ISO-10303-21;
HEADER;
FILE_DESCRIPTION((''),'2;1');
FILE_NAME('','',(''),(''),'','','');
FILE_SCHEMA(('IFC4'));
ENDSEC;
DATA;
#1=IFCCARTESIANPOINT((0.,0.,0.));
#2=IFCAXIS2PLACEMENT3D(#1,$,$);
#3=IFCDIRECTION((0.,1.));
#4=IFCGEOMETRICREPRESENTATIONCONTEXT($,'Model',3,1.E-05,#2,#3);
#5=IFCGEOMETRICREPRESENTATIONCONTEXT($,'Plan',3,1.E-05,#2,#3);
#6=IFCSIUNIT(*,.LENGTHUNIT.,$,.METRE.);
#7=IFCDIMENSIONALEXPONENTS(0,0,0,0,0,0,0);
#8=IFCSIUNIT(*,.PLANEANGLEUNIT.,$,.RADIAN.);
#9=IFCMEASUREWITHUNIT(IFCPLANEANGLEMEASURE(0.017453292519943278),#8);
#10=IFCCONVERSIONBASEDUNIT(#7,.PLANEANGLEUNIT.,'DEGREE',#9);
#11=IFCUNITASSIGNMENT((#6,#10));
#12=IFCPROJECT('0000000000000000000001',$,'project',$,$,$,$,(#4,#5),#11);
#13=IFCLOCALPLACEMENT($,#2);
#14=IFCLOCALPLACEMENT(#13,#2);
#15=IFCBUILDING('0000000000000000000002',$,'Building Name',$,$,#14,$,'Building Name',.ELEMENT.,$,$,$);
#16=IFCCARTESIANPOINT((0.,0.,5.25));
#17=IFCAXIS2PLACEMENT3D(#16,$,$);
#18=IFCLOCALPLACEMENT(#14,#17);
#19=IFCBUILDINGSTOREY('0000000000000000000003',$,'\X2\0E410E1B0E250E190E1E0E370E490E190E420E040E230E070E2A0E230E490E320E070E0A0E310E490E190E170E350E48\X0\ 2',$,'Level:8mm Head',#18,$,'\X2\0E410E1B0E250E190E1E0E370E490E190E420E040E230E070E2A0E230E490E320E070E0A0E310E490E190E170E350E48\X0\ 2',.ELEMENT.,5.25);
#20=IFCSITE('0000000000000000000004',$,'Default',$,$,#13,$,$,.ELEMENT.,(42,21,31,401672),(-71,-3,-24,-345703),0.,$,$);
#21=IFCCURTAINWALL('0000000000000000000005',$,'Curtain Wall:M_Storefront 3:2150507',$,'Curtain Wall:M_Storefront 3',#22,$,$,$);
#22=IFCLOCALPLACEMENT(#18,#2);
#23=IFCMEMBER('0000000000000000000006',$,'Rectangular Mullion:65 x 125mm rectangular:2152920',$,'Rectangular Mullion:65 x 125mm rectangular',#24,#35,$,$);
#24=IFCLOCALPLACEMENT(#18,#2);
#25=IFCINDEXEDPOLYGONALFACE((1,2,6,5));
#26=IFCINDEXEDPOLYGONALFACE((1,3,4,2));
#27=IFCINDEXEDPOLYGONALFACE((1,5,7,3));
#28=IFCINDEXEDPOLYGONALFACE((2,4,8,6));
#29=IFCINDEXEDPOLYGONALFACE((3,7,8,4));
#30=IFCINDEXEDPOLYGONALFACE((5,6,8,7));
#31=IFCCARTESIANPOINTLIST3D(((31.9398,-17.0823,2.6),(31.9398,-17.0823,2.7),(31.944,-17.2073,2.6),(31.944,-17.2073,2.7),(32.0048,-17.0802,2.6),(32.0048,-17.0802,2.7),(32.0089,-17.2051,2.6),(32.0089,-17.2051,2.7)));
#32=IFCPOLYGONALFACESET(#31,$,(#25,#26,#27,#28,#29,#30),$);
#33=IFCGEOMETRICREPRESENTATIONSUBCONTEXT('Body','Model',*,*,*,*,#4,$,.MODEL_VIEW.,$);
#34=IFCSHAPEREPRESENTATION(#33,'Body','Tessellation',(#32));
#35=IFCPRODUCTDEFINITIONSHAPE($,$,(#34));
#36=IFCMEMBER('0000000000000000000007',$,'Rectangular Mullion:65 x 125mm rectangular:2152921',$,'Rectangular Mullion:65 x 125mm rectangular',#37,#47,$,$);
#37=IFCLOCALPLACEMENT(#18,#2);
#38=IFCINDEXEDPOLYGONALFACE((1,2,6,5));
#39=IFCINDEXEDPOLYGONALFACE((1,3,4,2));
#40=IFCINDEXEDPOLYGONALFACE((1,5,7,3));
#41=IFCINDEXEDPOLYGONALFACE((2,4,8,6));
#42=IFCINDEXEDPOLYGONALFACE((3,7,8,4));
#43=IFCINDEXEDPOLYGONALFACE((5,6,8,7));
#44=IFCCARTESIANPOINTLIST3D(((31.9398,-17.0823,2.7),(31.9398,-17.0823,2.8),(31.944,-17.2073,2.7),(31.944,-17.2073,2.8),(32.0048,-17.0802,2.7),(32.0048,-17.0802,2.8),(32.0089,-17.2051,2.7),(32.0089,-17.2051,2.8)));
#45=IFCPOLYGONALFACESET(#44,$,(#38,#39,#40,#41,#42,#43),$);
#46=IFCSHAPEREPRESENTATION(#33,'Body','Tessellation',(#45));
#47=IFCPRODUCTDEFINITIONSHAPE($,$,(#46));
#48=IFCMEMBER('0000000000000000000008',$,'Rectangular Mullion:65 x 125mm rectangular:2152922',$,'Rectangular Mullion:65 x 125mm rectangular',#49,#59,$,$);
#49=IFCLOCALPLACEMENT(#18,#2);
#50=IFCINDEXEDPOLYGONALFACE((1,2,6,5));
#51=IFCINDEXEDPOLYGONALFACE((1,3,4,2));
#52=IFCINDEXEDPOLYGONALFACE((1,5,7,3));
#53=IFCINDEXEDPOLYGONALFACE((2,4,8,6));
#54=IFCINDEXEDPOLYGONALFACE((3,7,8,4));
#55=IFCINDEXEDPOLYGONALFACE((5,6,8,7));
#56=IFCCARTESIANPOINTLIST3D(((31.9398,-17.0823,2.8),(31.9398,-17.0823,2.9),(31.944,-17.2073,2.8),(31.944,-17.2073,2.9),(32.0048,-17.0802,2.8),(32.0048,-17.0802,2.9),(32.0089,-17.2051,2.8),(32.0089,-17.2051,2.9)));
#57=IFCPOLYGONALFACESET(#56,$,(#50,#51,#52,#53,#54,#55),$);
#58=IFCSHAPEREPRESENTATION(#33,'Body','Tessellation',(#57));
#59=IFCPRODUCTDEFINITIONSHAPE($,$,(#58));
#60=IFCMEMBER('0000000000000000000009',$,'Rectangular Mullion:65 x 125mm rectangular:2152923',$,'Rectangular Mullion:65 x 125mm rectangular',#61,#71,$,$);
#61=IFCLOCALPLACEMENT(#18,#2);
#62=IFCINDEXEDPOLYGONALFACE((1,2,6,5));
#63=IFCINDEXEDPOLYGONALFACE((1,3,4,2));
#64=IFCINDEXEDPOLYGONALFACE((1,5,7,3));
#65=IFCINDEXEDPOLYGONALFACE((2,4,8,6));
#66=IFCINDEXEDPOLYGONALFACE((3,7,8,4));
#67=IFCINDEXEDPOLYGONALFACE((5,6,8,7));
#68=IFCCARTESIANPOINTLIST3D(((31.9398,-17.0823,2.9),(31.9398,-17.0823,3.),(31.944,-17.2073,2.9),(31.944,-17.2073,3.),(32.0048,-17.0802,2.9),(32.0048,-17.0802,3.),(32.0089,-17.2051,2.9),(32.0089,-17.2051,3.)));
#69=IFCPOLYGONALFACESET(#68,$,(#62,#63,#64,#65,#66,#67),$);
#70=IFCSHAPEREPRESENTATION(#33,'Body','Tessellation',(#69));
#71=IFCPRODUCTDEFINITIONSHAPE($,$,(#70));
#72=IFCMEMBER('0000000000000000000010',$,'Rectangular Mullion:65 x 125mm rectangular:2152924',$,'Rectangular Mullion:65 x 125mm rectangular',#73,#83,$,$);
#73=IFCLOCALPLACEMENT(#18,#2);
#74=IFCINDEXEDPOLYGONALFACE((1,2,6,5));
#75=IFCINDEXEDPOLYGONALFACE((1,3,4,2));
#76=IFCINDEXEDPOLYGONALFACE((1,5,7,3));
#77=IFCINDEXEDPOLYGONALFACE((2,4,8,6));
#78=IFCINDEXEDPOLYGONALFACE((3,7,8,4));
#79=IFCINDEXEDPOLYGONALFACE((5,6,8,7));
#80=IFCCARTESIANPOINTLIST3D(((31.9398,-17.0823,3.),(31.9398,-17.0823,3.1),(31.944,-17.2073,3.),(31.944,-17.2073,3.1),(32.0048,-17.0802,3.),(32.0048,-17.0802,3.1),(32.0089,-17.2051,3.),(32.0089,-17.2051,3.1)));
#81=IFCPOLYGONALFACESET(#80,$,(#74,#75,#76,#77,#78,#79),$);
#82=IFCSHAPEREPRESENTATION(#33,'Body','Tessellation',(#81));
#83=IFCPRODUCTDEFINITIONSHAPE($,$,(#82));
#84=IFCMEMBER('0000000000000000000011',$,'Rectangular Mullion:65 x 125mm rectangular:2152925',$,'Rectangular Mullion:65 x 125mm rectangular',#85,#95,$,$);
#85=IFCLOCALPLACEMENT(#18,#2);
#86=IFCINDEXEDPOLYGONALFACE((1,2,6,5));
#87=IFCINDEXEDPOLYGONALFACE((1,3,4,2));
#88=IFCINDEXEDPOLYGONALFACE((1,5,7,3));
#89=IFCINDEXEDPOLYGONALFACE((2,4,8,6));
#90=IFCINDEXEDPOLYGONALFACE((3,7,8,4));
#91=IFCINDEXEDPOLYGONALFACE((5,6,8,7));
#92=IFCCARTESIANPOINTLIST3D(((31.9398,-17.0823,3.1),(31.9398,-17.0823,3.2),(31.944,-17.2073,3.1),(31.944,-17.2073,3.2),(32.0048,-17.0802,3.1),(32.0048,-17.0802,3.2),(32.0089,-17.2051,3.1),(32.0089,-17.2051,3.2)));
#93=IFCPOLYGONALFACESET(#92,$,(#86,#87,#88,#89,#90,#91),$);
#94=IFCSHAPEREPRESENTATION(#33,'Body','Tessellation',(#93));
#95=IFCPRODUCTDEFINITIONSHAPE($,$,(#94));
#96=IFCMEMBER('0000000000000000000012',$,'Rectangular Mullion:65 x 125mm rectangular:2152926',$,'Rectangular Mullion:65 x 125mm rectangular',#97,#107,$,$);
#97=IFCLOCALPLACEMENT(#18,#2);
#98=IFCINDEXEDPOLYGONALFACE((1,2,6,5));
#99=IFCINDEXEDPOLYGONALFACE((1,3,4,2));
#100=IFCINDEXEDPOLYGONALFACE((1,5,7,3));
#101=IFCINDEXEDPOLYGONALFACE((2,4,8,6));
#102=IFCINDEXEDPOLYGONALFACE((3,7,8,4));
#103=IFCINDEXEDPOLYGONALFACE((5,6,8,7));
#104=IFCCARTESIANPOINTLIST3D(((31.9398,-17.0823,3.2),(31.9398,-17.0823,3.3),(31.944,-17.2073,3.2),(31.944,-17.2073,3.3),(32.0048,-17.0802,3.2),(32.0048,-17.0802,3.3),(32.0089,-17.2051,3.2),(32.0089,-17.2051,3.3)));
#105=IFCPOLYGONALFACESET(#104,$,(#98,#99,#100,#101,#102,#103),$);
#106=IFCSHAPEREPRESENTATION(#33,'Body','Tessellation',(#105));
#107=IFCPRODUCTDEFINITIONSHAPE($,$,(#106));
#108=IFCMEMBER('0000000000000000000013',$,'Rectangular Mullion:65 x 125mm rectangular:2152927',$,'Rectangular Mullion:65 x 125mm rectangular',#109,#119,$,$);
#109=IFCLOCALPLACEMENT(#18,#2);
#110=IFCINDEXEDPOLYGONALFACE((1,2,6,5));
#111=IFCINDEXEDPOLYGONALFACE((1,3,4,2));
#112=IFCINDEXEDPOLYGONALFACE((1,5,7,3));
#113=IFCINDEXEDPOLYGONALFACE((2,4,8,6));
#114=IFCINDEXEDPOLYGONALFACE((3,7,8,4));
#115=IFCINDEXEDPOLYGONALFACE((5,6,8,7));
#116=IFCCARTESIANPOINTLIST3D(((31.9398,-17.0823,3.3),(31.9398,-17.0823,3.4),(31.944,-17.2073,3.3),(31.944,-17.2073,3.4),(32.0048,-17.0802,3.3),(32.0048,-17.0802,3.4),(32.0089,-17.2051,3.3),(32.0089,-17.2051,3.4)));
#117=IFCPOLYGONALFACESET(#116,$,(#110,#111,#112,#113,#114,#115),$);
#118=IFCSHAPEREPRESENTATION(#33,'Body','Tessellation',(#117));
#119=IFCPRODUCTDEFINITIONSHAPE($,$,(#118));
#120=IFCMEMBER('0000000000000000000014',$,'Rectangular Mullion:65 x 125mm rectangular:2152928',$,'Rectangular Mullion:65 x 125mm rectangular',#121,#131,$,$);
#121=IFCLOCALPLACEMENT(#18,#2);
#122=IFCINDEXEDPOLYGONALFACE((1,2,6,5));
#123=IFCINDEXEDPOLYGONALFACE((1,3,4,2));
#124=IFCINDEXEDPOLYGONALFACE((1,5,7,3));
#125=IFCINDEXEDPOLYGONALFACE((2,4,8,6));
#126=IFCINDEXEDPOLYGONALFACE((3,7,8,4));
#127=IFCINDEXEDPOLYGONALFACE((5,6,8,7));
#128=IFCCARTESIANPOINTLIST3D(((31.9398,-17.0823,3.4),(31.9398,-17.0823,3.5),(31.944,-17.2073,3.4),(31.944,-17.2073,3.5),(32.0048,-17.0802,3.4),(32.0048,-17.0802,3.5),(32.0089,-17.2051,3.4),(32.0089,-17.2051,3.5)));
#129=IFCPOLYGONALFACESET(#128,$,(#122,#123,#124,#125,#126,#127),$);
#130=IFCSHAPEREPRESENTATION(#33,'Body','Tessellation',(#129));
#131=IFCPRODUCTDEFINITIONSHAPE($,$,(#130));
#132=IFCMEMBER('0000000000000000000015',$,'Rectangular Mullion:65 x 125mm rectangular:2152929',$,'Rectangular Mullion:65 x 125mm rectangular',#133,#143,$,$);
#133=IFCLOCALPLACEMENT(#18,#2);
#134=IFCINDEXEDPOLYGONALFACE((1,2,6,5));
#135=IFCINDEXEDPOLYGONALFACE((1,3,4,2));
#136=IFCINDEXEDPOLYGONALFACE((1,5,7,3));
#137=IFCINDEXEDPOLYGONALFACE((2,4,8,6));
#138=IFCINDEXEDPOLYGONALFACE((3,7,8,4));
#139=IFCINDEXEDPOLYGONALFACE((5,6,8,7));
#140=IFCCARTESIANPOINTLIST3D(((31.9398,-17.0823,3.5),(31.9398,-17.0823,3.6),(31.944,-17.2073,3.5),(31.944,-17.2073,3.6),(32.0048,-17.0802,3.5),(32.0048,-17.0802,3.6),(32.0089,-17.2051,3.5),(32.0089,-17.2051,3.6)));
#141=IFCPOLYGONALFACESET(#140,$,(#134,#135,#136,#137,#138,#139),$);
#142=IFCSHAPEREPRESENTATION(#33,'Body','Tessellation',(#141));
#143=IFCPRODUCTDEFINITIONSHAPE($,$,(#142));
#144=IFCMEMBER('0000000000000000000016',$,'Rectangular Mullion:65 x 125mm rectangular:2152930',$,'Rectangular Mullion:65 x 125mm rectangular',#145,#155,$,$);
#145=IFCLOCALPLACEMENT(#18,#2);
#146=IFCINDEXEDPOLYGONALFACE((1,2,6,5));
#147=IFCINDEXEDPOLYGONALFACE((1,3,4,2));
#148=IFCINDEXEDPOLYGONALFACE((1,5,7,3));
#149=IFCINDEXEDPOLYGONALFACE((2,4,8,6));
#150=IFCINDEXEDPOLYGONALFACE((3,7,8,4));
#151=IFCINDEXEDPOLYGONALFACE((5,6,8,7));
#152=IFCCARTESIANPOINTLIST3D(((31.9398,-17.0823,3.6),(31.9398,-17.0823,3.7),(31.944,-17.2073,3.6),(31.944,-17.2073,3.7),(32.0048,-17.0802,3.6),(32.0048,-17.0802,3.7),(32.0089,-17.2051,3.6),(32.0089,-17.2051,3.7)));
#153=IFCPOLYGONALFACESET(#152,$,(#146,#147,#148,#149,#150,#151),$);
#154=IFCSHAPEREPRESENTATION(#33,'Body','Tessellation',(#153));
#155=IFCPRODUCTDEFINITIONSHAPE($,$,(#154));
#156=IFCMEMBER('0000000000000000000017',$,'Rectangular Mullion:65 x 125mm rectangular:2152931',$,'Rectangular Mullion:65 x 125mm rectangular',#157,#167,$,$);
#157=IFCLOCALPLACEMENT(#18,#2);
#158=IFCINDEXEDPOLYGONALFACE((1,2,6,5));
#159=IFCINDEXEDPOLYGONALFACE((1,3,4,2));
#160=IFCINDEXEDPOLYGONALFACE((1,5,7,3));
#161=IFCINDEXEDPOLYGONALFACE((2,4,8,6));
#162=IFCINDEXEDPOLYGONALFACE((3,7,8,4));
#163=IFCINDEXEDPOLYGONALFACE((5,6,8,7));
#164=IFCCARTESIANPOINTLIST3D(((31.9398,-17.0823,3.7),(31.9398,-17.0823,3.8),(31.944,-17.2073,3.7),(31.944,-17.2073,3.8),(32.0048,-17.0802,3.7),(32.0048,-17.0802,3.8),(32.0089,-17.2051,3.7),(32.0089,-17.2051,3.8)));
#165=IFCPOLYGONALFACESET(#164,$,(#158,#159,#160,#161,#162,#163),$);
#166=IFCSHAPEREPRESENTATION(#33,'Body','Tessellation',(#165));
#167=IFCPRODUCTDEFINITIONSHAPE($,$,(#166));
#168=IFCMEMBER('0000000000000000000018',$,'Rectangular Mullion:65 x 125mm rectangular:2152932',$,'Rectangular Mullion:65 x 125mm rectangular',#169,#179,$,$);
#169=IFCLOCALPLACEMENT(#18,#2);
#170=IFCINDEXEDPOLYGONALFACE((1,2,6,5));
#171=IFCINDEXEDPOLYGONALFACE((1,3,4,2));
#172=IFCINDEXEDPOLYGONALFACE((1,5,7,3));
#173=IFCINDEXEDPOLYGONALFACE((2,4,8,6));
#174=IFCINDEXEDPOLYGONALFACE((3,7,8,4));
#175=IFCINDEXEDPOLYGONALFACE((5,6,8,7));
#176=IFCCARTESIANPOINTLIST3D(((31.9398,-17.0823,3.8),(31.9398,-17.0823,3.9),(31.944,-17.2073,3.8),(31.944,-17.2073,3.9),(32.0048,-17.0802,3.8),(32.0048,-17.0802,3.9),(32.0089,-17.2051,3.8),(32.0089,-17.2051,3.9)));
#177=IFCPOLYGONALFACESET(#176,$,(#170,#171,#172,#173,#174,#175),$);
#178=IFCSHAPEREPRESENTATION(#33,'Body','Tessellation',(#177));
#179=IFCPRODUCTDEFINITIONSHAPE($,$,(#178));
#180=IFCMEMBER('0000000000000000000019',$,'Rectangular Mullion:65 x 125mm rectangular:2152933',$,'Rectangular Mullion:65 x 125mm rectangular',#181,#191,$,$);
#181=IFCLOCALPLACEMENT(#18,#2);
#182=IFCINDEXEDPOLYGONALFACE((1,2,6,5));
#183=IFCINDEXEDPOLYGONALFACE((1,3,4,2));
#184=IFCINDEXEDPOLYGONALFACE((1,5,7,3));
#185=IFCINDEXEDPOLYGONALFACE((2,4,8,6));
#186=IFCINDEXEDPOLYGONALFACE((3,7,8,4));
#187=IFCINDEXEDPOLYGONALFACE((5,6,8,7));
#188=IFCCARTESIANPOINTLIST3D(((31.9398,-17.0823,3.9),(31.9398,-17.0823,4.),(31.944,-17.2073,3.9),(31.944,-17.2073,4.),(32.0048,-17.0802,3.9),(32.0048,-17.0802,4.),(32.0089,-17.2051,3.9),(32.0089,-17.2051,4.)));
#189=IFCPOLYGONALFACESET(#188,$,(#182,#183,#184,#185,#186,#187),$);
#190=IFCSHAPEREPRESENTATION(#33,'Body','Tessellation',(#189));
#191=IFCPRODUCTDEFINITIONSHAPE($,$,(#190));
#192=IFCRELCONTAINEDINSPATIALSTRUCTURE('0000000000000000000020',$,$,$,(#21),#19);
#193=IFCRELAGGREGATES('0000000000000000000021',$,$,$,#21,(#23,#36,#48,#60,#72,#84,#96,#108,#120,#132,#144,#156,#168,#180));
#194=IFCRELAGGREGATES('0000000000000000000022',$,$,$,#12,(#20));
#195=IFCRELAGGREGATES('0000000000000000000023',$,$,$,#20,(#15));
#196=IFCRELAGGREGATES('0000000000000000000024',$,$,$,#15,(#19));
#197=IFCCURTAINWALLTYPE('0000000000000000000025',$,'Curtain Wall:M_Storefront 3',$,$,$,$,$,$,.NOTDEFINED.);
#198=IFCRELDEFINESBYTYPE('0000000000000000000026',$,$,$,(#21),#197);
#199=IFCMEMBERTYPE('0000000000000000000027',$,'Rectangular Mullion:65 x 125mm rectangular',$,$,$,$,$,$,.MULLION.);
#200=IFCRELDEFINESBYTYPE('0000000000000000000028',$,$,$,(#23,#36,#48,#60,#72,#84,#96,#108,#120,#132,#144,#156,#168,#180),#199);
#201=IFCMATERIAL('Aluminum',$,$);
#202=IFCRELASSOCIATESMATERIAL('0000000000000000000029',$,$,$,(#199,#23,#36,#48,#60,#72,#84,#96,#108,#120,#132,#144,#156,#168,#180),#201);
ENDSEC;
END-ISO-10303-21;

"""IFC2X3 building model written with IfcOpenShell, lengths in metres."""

from ifc_helpers import new_model, entity, si_unit, converted_unit, direction, frame, origin, origin_2d_with_axis, place, context, subcontext, project, spatial, rectangle, extrude, source, transform, mapped, material, type_object, type_shapes, element, aggregate, save


model = new_model("IFC2X3")

# Units and contexts
model_context = context("Model", 3, precision=1e-05, world=origin(), true_north=direction((0.0, 1.0)))
plan_context = context("Plan", 3, precision=1e-05, world=origin(), true_north=direction((0.0, 1.0)))
body_context = subcontext(model_context, "Body", "Model", "MODEL_VIEW")
ifc_project = project(units=[si_unit("LENGTHUNIT", "METRE"), converted_unit("PLANEANGLEUNIT", "DEGREE", entity("IfcPlaneAngleMeasure", 0.017453292519943278), si_unit("PLANEANGLEUNIT", "RADIAN"), dimensions=[0, 0, 0, 0, 0, 0, 0])], contexts=[model_context, plan_context])

# Site, building, storey
site_placement = place(None, origin())
site = spatial("IfcSite", under=ifc_project, at=site_placement, Name="Default", CompositionType="ELEMENT", RefLatitude=(42, 21, 31, 401672), RefLongitude=(-71, -3, -24, -345703), RefElevation=0.0)
building_placement = place(site_placement, origin())
building = spatial("IfcBuilding", under=site, at=building_placement, Name="Building Name", LongName="Building Name", CompositionType="ELEMENT")
storey_placement = place(building_placement, frame((0.0, 0.0, 5.25)))
storey = spatial("IfcBuildingStorey", under=building, at=storey_placement, Name="แปลนพื้นโครงสร้างชั้นที่ 2", ObjectType="Level:8mm Head", LongName="แปลนพื้นโครงสร้างชั้นที่ 2", CompositionType="ELEMENT", Elevation=5.25)

# Curtain wall, members
curtain_wall_type = type_object("IfcCurtainWallType", Name="Curtain Wall:M_Storefront 3", PredefinedType="NOTDEFINED")
curtain_wall_placement = place(storey_placement, frame((0.0, 0.0, -5.25)))
curtain_wall = element("IfcCurtainWall", 1, at=curtain_wall_placement, inside=storey, type_object=curtain_wall_type, Name="Curtain Wall:M_Storefront 3:2150507", ObjectType="Curtain Wall:M_Storefront 3")
ifc_material_1 = material(Name="Aluminum")
member_type_1 = type_object("IfcMemberType", Name="Rectangular Mullion:65 x 125mm rectangular", PredefinedType="MULLION", material=ifc_material_1)
shared_shape_1 = source(origin(), body_context, "Body", "SweptSolid", [
    extrude(rectangle(XDim=0.065, YDim=0.125, at=origin_2d_with_axis()), frame((-0.0325, 0.0, -0.1), z_axis=(0.0, 0.0, 1.0), x_axis=(-1.0, 0.0, 0.0)), (0.0, 0.0, 1.0), 0.1),
])
type_shapes(member_type_1, [shared_shape_1])
member_1_placement = place(curtain_wall_placement, frame((31.9419, -17.1448, 7.95), z_axis=(0.0, 0.0, 1.0), x_axis=(-0.99946, -0.032862, 0.0)))
member_1 = element("IfcMember", 2, at=member_1_placement, type_object=member_type_1, material=ifc_material_1, Name="Rectangular Mullion:65 x 125mm rectangular:2152920", ObjectType="Rectangular Mullion:65 x 125mm rectangular", context=body_context, shape_type="MappedRepresentation", body=[
    mapped(shared_shape_1, transform((0.0, 0.0, 0.0), scale=1.0)),
])
member_2_placement = place(curtain_wall_placement, frame((31.9419, -17.1448, 8.05), z_axis=(0.0, 0.0, 1.0), x_axis=(-0.99946, -0.032862, 0.0)))
member_2 = element("IfcMember", 3, at=member_2_placement, type_object=member_type_1, material=ifc_material_1, Name="Rectangular Mullion:65 x 125mm rectangular:2152921", ObjectType="Rectangular Mullion:65 x 125mm rectangular", context=body_context, shape_type="MappedRepresentation", body=[
    mapped(shared_shape_1, transform((0.0, 0.0, 0.0), scale=1.0)),
])
member_3_placement = place(curtain_wall_placement, frame((31.9419, -17.1448, 8.15), z_axis=(0.0, 0.0, 1.0), x_axis=(-0.99946, -0.032862, 0.0)))
member_3 = element("IfcMember", 4, at=member_3_placement, type_object=member_type_1, material=ifc_material_1, Name="Rectangular Mullion:65 x 125mm rectangular:2152922", ObjectType="Rectangular Mullion:65 x 125mm rectangular", context=body_context, shape_type="MappedRepresentation", body=[
    mapped(shared_shape_1, transform((0.0, 0.0, 0.0), scale=1.0)),
])
member_4_placement = place(curtain_wall_placement, frame((31.9419, -17.1448, 8.25), z_axis=(0.0, 0.0, 1.0), x_axis=(-0.99946, -0.032862, 0.0)))
member_4 = element("IfcMember", 5, at=member_4_placement, type_object=member_type_1, material=ifc_material_1, Name="Rectangular Mullion:65 x 125mm rectangular:2152923", ObjectType="Rectangular Mullion:65 x 125mm rectangular", context=body_context, shape_type="MappedRepresentation", body=[
    mapped(shared_shape_1, transform((0.0, 0.0, 0.0), scale=1.0)),
])
member_5_placement = place(curtain_wall_placement, frame((31.9419, -17.1448, 8.35), z_axis=(0.0, 0.0, 1.0), x_axis=(-0.99946, -0.032862, 0.0)))
member_5 = element("IfcMember", 6, at=member_5_placement, type_object=member_type_1, material=ifc_material_1, Name="Rectangular Mullion:65 x 125mm rectangular:2152924", ObjectType="Rectangular Mullion:65 x 125mm rectangular", context=body_context, shape_type="MappedRepresentation", body=[
    mapped(shared_shape_1, transform((0.0, 0.0, 0.0), scale=1.0)),
])
member_6_placement = place(curtain_wall_placement, frame((31.9419, -17.1448, 8.45), z_axis=(0.0, 0.0, 1.0), x_axis=(-0.99946, -0.032862, 0.0)))
member_6 = element("IfcMember", 7, at=member_6_placement, type_object=member_type_1, material=ifc_material_1, Name="Rectangular Mullion:65 x 125mm rectangular:2152925", ObjectType="Rectangular Mullion:65 x 125mm rectangular", context=body_context, shape_type="MappedRepresentation", body=[
    mapped(shared_shape_1, transform((0.0, 0.0, 0.0), scale=1.0)),
])
member_7_placement = place(curtain_wall_placement, frame((31.9419, -17.1448, 8.55), z_axis=(0.0, 0.0, 1.0), x_axis=(-0.99946, -0.032862, 0.0)))
member_7 = element("IfcMember", 8, at=member_7_placement, type_object=member_type_1, material=ifc_material_1, Name="Rectangular Mullion:65 x 125mm rectangular:2152926", ObjectType="Rectangular Mullion:65 x 125mm rectangular", context=body_context, shape_type="MappedRepresentation", body=[
    mapped(shared_shape_1, transform((0.0, 0.0, 0.0), scale=1.0)),
])
member_8_placement = place(curtain_wall_placement, frame((31.9419, -17.1448, 8.65), z_axis=(0.0, 0.0, 1.0), x_axis=(-0.99946, -0.032862, 0.0)))
member_8 = element("IfcMember", 9, at=member_8_placement, type_object=member_type_1, material=ifc_material_1, Name="Rectangular Mullion:65 x 125mm rectangular:2152927", ObjectType="Rectangular Mullion:65 x 125mm rectangular", context=body_context, shape_type="MappedRepresentation", body=[
    mapped(shared_shape_1, transform((0.0, 0.0, 0.0), scale=1.0)),
])
member_9_placement = place(curtain_wall_placement, frame((31.9419, -17.1448, 8.75), z_axis=(0.0, 0.0, 1.0), x_axis=(-0.99946, -0.032862, 0.0)))
member_9 = element("IfcMember", 10, at=member_9_placement, type_object=member_type_1, material=ifc_material_1, Name="Rectangular Mullion:65 x 125mm rectangular:2152928", ObjectType="Rectangular Mullion:65 x 125mm rectangular", context=body_context, shape_type="MappedRepresentation", body=[
    mapped(shared_shape_1, transform((0.0, 0.0, 0.0), scale=1.0)),
])
member_10_placement = place(curtain_wall_placement, frame((31.9419, -17.1448, 8.85), z_axis=(0.0, 0.0, 1.0), x_axis=(-0.99946, -0.032862, 0.0)))
member_10 = element("IfcMember", 11, at=member_10_placement, type_object=member_type_1, material=ifc_material_1, Name="Rectangular Mullion:65 x 125mm rectangular:2152929", ObjectType="Rectangular Mullion:65 x 125mm rectangular", context=body_context, shape_type="MappedRepresentation", body=[
    mapped(shared_shape_1, transform((0.0, 0.0, 0.0), scale=1.0)),
])
member_11_placement = place(curtain_wall_placement, frame((31.9419, -17.1448, 8.95), z_axis=(0.0, 0.0, 1.0), x_axis=(-0.99946, -0.032862, 0.0)))
member_11 = element("IfcMember", 12, at=member_11_placement, type_object=member_type_1, material=ifc_material_1, Name="Rectangular Mullion:65 x 125mm rectangular:2152930", ObjectType="Rectangular Mullion:65 x 125mm rectangular", context=body_context, shape_type="MappedRepresentation", body=[
    mapped(shared_shape_1, transform((0.0, 0.0, 0.0), scale=1.0)),
])
member_12_placement = place(curtain_wall_placement, frame((31.9419, -17.1448, 9.05), z_axis=(0.0, 0.0, 1.0), x_axis=(-0.99946, -0.032862, 0.0)))
member_12 = element("IfcMember", 13, at=member_12_placement, type_object=member_type_1, material=ifc_material_1, Name="Rectangular Mullion:65 x 125mm rectangular:2152931", ObjectType="Rectangular Mullion:65 x 125mm rectangular", context=body_context, shape_type="MappedRepresentation", body=[
    mapped(shared_shape_1, transform((0.0, 0.0, 0.0), scale=1.0)),
])
member_13_placement = place(curtain_wall_placement, frame((31.9419, -17.1448, 9.15), z_axis=(0.0, 0.0, 1.0), x_axis=(-0.99946, -0.032862, 0.0)))
member_13 = element("IfcMember", 14, at=member_13_placement, type_object=member_type_1, material=ifc_material_1, Name="Rectangular Mullion:65 x 125mm rectangular:2152932", ObjectType="Rectangular Mullion:65 x 125mm rectangular", context=body_context, shape_type="MappedRepresentation", body=[
    mapped(shared_shape_1, transform((0.0, 0.0, 0.0), scale=1.0)),
])
member_14_placement = place(curtain_wall_placement, frame((31.9419, -17.1448, 9.25), z_axis=(0.0, 0.0, 1.0), x_axis=(-0.99946, -0.032862, 0.0)))
member_14 = element("IfcMember", 15, at=member_14_placement, type_object=member_type_1, material=ifc_material_1, Name="Rectangular Mullion:65 x 125mm rectangular:2152933", ObjectType="Rectangular Mullion:65 x 125mm rectangular", context=body_context, shape_type="MappedRepresentation", body=[
    mapped(shared_shape_1, transform((0.0, 0.0, 0.0), scale=1.0)),
])
aggregate(curtain_wall, [member_1, member_2, member_3, member_4, member_5, member_6, member_7, member_8, member_9, member_10, member_11, member_12, member_13, member_14])

save(model, "model.ifc")
